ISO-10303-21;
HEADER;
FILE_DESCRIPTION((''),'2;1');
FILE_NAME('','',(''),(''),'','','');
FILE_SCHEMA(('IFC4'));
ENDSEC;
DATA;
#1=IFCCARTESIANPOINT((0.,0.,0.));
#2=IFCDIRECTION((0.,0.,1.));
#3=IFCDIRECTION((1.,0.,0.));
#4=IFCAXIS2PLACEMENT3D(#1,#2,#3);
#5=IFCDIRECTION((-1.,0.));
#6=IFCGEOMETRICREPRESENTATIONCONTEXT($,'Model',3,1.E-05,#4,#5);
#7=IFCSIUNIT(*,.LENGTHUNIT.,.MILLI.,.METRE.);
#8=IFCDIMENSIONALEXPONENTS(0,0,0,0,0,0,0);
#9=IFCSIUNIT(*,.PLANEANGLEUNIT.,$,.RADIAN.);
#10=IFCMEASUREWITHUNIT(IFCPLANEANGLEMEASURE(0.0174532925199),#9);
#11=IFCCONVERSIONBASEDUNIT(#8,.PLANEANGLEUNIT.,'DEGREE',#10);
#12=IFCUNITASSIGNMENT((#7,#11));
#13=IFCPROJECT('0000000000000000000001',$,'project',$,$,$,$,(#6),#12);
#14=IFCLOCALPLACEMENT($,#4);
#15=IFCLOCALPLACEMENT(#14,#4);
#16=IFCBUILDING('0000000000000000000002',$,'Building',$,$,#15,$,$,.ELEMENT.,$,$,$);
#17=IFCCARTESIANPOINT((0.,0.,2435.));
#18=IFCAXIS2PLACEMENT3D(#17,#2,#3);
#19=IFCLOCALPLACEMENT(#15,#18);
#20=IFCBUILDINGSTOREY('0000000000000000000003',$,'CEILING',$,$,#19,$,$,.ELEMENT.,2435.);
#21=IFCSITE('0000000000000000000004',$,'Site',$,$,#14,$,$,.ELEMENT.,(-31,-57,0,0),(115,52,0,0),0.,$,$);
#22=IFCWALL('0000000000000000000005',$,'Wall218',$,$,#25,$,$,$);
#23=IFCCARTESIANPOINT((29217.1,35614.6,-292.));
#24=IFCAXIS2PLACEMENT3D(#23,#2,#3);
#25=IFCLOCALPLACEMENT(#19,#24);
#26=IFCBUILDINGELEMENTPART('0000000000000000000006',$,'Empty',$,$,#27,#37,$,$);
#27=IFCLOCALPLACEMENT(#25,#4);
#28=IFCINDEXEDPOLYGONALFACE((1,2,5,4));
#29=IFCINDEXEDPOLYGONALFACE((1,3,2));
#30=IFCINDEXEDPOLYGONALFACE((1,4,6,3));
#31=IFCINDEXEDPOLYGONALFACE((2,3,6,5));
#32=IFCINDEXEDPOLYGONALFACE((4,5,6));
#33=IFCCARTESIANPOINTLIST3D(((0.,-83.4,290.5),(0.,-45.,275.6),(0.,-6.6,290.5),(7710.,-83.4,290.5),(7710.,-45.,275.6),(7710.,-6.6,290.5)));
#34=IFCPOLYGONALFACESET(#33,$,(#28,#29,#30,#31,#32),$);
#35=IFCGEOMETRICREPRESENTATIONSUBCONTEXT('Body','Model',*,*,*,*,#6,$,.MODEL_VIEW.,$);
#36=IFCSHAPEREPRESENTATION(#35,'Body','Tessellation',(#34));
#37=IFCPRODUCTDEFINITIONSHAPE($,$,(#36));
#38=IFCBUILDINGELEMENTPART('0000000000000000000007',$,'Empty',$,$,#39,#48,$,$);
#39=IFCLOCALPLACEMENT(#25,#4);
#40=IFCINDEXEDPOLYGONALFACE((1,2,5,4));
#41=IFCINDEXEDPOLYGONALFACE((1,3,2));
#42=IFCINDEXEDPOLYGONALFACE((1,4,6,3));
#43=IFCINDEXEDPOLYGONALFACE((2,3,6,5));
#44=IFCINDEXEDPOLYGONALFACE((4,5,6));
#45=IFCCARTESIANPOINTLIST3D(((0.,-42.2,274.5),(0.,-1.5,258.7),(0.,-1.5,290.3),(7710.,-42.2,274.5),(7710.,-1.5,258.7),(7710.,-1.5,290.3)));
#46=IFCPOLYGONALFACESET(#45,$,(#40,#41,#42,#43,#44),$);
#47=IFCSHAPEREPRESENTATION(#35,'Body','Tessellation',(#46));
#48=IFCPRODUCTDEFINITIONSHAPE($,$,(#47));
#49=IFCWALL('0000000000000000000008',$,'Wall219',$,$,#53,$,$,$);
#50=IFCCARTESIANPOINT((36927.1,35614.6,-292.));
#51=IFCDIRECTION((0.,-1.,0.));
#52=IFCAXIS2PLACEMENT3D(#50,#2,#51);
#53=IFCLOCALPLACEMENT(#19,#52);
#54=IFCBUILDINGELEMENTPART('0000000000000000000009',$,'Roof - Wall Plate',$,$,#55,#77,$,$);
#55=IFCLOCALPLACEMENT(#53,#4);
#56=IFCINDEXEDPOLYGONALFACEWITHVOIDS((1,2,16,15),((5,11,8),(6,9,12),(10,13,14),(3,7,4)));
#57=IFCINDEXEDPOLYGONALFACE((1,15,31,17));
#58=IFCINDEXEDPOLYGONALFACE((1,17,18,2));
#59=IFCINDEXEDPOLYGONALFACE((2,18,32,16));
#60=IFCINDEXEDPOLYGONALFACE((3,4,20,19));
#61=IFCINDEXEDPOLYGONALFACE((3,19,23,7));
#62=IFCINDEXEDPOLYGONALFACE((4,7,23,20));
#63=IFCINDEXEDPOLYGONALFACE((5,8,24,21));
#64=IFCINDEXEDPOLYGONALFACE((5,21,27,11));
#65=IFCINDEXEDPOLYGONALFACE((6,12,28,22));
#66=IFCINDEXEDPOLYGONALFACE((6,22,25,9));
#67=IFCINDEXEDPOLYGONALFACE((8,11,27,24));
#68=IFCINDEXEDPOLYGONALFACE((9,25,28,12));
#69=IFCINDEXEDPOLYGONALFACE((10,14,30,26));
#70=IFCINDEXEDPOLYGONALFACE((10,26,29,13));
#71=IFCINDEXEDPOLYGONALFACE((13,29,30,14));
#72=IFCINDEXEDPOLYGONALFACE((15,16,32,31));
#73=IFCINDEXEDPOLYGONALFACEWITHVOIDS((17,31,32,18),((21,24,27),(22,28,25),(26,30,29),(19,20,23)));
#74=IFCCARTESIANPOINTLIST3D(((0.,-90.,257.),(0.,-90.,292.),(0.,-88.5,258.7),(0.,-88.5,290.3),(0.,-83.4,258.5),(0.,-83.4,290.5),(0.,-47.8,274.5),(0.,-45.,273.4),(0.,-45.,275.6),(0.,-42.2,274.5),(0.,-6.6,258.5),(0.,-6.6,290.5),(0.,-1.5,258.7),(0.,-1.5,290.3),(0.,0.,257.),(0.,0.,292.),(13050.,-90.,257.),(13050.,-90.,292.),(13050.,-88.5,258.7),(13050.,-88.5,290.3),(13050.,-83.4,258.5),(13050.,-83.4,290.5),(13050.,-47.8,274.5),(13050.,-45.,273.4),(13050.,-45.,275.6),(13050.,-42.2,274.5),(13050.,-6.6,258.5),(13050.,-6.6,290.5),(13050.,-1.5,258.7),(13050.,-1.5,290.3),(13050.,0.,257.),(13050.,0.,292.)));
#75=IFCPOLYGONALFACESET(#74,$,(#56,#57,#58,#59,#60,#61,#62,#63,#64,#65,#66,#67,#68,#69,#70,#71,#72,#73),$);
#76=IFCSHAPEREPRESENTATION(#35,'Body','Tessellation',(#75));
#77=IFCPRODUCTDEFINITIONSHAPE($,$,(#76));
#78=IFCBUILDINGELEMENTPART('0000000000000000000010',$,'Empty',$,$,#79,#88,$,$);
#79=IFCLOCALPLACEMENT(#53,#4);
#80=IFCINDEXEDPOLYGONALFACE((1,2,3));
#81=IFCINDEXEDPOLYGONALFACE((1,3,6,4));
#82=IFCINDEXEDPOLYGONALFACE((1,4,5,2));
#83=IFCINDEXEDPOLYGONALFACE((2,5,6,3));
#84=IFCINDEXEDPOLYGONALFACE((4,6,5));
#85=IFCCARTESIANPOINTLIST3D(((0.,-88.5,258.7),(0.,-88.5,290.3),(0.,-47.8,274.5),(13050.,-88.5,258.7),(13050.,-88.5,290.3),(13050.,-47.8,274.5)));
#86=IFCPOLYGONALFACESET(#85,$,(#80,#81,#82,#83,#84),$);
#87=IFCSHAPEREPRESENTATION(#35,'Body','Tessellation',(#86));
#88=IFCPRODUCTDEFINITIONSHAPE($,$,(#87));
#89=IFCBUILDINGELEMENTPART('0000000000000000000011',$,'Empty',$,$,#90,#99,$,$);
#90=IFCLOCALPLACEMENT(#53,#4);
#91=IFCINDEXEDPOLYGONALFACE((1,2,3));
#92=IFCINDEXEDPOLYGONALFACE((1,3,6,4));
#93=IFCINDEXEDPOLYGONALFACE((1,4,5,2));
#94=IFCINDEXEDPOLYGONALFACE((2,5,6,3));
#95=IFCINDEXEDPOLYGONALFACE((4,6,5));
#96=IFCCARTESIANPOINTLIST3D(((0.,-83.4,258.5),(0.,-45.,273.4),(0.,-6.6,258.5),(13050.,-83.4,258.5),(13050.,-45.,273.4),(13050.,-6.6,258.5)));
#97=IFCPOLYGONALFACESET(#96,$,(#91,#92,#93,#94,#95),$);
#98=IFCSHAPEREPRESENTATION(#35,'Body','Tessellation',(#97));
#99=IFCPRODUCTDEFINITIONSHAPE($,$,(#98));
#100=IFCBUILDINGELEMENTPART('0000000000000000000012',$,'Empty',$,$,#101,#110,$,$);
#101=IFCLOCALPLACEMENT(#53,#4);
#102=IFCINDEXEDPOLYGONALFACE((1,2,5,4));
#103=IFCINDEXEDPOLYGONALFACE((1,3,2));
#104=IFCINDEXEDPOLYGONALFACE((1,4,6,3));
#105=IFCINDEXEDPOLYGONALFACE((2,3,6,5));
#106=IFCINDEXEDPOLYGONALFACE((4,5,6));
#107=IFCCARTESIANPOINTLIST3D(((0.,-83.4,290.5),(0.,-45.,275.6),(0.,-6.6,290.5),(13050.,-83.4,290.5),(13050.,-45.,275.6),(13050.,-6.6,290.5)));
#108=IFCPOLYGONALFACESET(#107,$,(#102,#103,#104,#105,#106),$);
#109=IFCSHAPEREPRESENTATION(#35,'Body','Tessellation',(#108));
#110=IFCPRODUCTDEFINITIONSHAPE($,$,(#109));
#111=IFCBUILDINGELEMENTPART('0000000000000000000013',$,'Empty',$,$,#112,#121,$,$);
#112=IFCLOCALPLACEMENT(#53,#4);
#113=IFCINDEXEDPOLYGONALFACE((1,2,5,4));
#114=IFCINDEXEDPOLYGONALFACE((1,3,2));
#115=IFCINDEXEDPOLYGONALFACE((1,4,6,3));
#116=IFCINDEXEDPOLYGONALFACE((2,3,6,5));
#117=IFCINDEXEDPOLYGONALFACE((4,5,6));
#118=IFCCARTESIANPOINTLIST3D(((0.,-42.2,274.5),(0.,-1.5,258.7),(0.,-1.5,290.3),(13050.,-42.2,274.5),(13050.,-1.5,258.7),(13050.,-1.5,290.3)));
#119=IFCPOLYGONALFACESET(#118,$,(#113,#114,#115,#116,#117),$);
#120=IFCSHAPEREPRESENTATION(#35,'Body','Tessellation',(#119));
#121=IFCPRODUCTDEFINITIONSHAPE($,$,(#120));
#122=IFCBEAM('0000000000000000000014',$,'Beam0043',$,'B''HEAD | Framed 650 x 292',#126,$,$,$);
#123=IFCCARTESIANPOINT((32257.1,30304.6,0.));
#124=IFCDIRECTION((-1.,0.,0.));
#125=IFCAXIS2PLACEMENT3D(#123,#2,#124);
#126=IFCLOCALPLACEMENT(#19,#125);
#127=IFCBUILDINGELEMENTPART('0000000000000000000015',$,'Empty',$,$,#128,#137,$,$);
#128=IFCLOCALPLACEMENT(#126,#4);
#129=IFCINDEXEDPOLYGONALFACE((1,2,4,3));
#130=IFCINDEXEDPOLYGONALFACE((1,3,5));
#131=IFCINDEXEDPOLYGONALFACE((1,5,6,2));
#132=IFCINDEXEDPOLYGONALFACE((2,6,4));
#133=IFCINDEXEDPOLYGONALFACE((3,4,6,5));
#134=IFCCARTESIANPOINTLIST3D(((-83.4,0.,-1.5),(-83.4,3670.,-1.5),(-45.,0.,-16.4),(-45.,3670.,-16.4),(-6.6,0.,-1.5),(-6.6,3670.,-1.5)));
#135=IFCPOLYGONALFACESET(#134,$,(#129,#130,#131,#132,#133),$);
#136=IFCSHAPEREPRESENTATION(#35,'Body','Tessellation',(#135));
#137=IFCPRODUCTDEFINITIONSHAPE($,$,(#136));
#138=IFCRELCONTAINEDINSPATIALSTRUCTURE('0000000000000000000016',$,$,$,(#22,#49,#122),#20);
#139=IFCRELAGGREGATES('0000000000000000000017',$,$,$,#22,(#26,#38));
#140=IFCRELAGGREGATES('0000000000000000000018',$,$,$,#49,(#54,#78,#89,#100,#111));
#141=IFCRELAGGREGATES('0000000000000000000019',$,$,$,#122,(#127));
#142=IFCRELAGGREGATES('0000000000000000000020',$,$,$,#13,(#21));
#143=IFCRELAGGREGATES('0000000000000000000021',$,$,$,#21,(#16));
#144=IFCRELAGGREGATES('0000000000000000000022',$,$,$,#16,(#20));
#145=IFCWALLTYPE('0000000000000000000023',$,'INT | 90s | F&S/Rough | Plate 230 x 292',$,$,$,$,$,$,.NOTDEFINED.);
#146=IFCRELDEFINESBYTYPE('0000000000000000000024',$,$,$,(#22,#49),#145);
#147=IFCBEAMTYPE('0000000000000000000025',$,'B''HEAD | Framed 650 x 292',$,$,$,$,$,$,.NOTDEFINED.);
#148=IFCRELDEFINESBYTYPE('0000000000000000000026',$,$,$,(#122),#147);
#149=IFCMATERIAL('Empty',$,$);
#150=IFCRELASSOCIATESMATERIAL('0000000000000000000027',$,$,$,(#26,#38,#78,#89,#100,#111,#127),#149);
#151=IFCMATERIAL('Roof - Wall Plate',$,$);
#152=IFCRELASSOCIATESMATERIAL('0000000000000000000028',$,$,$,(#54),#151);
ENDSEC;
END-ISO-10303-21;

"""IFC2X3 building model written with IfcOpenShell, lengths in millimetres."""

from ifc_helpers import new_model, entity, si_unit, converted_unit, direction, frame, origin_with_axes, place, context, subcontext, project, spatial, polyline, outline, extrude, material, type_object, element, aggregate, save


model = new_model("IFC2X3")

# Units and contexts
model_context = context("Model", 3, precision=1e-05, world=origin_with_axes(), true_north=direction((-1.0, 0.0)))
body_context = subcontext(model_context, "Body", "Model", "MODEL_VIEW")
ifc_project = project(units=[si_unit("LENGTHUNIT", "METRE", prefix="MILLI"), converted_unit("PLANEANGLEUNIT", "DEGREE", entity("IfcPlaneAngleMeasure", 0.0174532925199), si_unit("PLANEANGLEUNIT", "RADIAN"), dimensions=[0, 0, 0, 0, 0, 0, 0])], contexts=[model_context])

# Site, building, storey
site_placement = place(None, origin_with_axes())
site = spatial("IfcSite", under=ifc_project, at=site_placement, Name="Site", CompositionType="ELEMENT", RefLatitude=(-31, -57, 0, 0), RefLongitude=(115, 52, 0, 0), RefElevation=0.0)
building_placement = place(site_placement, origin_with_axes())
building = spatial("IfcBuilding", under=site, at=building_placement, Name="Building", CompositionType="ELEMENT")
storey_placement = place(building_placement, frame((0.0, 0.0, 2435.0), z_axis=(0.0, 0.0, 1.0), x_axis=(1.0, 0.0, 0.0)))
storey = spatial("IfcBuildingStorey", under=building, at=storey_placement, Name="CEILING", CompositionType="ELEMENT", Elevation=2435.0)

# Walls, building element parts
wall_type = type_object("IfcWallType", Name="INT | 90s | F&S/Rough | Plate 230 x 292", PredefinedType="NOTDEFINED")
wall_1_placement = place(storey_placement, frame((29217.1, 35614.6, -292.0), z_axis=(0.0, 0.0, 1.0), x_axis=(1.0, 0.0, 0.0)))
wall_1 = element("IfcWall", 1, at=wall_1_placement, inside=storey, type_object=wall_type, Name="Wall218")
ifc_material_1 = material(Name="Empty")
building_element_part_1_placement = place(wall_1_placement, origin_with_axes())
building_element_part_1 = element("IfcBuildingElementPart", 2, at=building_element_part_1_placement, material=ifc_material_1, Name="Empty", context=body_context, shape_type="SweptSolid", body=[
    extrude(outline(polyline([(-45.0, 275.6), (-6.6, 290.5), (-83.4, 290.5), (-45.0, 275.6)])), frame((0.0, 0.0, 0.0), z_axis=(1.0, 0.0, 0.0), x_axis=(0.0, 1.0, 0.0)), (0.0, 0.0, 1.0), 7710.0),
])
building_element_part_2_placement = place(wall_1_placement, origin_with_axes())
building_element_part_2 = element("IfcBuildingElementPart", 3, at=building_element_part_2_placement, material=ifc_material_1, Name="Empty", context=body_context, shape_type="SweptSolid", body=[
    extrude(outline(polyline([(-42.2, 274.5), (-1.5, 258.7), (-1.5, 290.3), (-42.2, 274.5)])), frame((0.0, 0.0, 0.0), z_axis=(1.0, 0.0, 0.0), x_axis=(0.0, 1.0, 0.0)), (0.0, 0.0, 1.0), 7710.0),
])
aggregate(wall_1, [building_element_part_1, building_element_part_2])
wall_2_placement = place(storey_placement, frame((36927.1, 35614.6, -292.0), z_axis=(0.0, 0.0, 1.0), x_axis=(0.0, -1.0, 0.0)))
wall_2 = element("IfcWall", 4, at=wall_2_placement, inside=storey, type_object=wall_type, Name="Wall219")
ifc_material_2 = material(Name="Roof - Wall Plate")
building_element_part_3_placement = place(wall_2_placement, origin_with_axes())
building_element_part_3 = element("IfcBuildingElementPart", 5, at=building_element_part_3_placement, material=ifc_material_2, Name="Roof - Wall Plate", context=body_context, shape_type="SweptSolid", body=[
    extrude(outline(polyline([(-90.0, 257.0), (0.0, 257.0), (0.0, 292.0), (-90.0, 292.0), (-90.0, 257.0)]), holes=[polyline([(-83.4, 290.5), (-6.6, 290.5), (-45.0, 275.6), (-83.4, 290.5)]), polyline([(-42.2, 274.5), (-1.5, 290.3), (-1.5, 258.7), (-42.2, 274.5)]), polyline([(-6.6, 258.5), (-83.4, 258.5), (-45.0, 273.4), (-6.6, 258.5)]), polyline([(-88.5, 258.7), (-88.5, 290.3), (-47.8, 274.5), (-88.5, 258.7)])]), frame((0.0, 0.0, 0.0), z_axis=(1.0, 0.0, 0.0), x_axis=(0.0, 1.0, 0.0)), (0.0, 0.0, 1.0), 13050.0),
])
building_element_part_4_placement = place(wall_2_placement, origin_with_axes())
building_element_part_4 = element("IfcBuildingElementPart", 6, at=building_element_part_4_placement, material=ifc_material_1, Name="Empty", context=body_context, shape_type="SweptSolid", body=[
    extrude(outline(polyline([(-47.8, 274.5), (-88.5, 290.3), (-88.5, 258.7), (-47.8, 274.5)])), frame((0.0, 0.0, 0.0), z_axis=(1.0, 0.0, 0.0), x_axis=(0.0, 1.0, 0.0)), (0.0, 0.0, 1.0), 13050.0),
])
building_element_part_5_placement = place(wall_2_placement, origin_with_axes())
building_element_part_5 = element("IfcBuildingElementPart", 7, at=building_element_part_5_placement, material=ifc_material_1, Name="Empty", context=body_context, shape_type="SweptSolid", body=[
    extrude(outline(polyline([(-6.6, 258.5), (-45.0, 273.4), (-83.4, 258.5), (-6.6, 258.5)])), frame((0.0, 0.0, 0.0), z_axis=(1.0, 0.0, 0.0), x_axis=(0.0, 1.0, 0.0)), (0.0, 0.0, 1.0), 13050.0),
])
building_element_part_6_placement = place(wall_2_placement, origin_with_axes())
building_element_part_6 = element("IfcBuildingElementPart", 8, at=building_element_part_6_placement, material=ifc_material_1, Name="Empty", context=body_context, shape_type="SweptSolid", body=[
    extrude(outline(polyline([(-45.0, 275.6), (-6.6, 290.5), (-83.4, 290.5), (-45.0, 275.6)])), frame((0.0, 0.0, 0.0), z_axis=(1.0, 0.0, 0.0), x_axis=(0.0, 1.0, 0.0)), (0.0, 0.0, 1.0), 13050.0),
])
building_element_part_7_placement = place(wall_2_placement, origin_with_axes())
building_element_part_7 = element("IfcBuildingElementPart", 9, at=building_element_part_7_placement, material=ifc_material_1, Name="Empty", context=body_context, shape_type="SweptSolid", body=[
    extrude(outline(polyline([(-42.2, 274.5), (-1.5, 258.7), (-1.5, 290.3), (-42.2, 274.5)])), frame((0.0, 0.0, 0.0), z_axis=(1.0, 0.0, 0.0), x_axis=(0.0, 1.0, 0.0)), (0.0, 0.0, 1.0), 13050.0),
])
aggregate(wall_2, [building_element_part_3, building_element_part_4, building_element_part_5, building_element_part_6, building_element_part_7])

# Beam, building element part
beam_type = type_object("IfcBeamType", Name="B'HEAD | Framed 650 x 292", PredefinedType="NOTDEFINED")
beam_placement = place(storey_placement, frame((32257.1, 30304.6, 0.0), z_axis=(0.0, 0.0, 1.0), x_axis=(-1.0, 0.0, 0.0)))
beam = element("IfcBeam", 10, at=beam_placement, inside=storey, type_object=beam_type, Name="Beam0043", ObjectType="B'HEAD | Framed 650 x 292")
building_element_part_8_placement = place(beam_placement, origin_with_axes())
building_element_part_8 = element("IfcBuildingElementPart", 11, at=building_element_part_8_placement, material=ifc_material_1, Name="Empty", context=body_context, shape_type="SweptSolid", body=[
    extrude(outline(polyline([(-45.0, -16.4), (-6.6, -1.5), (-83.4, -1.5), (-45.0, -16.4)])), frame((0.0, 3670.0, 0.0), z_axis=(0.0, -1.0, 0.0), x_axis=(1.0, 0.0, 0.0)), (0.0, 0.0, 1.0), 3670.0),
])
aggregate(beam, [building_element_part_8])

save(model, "model.ifc")
